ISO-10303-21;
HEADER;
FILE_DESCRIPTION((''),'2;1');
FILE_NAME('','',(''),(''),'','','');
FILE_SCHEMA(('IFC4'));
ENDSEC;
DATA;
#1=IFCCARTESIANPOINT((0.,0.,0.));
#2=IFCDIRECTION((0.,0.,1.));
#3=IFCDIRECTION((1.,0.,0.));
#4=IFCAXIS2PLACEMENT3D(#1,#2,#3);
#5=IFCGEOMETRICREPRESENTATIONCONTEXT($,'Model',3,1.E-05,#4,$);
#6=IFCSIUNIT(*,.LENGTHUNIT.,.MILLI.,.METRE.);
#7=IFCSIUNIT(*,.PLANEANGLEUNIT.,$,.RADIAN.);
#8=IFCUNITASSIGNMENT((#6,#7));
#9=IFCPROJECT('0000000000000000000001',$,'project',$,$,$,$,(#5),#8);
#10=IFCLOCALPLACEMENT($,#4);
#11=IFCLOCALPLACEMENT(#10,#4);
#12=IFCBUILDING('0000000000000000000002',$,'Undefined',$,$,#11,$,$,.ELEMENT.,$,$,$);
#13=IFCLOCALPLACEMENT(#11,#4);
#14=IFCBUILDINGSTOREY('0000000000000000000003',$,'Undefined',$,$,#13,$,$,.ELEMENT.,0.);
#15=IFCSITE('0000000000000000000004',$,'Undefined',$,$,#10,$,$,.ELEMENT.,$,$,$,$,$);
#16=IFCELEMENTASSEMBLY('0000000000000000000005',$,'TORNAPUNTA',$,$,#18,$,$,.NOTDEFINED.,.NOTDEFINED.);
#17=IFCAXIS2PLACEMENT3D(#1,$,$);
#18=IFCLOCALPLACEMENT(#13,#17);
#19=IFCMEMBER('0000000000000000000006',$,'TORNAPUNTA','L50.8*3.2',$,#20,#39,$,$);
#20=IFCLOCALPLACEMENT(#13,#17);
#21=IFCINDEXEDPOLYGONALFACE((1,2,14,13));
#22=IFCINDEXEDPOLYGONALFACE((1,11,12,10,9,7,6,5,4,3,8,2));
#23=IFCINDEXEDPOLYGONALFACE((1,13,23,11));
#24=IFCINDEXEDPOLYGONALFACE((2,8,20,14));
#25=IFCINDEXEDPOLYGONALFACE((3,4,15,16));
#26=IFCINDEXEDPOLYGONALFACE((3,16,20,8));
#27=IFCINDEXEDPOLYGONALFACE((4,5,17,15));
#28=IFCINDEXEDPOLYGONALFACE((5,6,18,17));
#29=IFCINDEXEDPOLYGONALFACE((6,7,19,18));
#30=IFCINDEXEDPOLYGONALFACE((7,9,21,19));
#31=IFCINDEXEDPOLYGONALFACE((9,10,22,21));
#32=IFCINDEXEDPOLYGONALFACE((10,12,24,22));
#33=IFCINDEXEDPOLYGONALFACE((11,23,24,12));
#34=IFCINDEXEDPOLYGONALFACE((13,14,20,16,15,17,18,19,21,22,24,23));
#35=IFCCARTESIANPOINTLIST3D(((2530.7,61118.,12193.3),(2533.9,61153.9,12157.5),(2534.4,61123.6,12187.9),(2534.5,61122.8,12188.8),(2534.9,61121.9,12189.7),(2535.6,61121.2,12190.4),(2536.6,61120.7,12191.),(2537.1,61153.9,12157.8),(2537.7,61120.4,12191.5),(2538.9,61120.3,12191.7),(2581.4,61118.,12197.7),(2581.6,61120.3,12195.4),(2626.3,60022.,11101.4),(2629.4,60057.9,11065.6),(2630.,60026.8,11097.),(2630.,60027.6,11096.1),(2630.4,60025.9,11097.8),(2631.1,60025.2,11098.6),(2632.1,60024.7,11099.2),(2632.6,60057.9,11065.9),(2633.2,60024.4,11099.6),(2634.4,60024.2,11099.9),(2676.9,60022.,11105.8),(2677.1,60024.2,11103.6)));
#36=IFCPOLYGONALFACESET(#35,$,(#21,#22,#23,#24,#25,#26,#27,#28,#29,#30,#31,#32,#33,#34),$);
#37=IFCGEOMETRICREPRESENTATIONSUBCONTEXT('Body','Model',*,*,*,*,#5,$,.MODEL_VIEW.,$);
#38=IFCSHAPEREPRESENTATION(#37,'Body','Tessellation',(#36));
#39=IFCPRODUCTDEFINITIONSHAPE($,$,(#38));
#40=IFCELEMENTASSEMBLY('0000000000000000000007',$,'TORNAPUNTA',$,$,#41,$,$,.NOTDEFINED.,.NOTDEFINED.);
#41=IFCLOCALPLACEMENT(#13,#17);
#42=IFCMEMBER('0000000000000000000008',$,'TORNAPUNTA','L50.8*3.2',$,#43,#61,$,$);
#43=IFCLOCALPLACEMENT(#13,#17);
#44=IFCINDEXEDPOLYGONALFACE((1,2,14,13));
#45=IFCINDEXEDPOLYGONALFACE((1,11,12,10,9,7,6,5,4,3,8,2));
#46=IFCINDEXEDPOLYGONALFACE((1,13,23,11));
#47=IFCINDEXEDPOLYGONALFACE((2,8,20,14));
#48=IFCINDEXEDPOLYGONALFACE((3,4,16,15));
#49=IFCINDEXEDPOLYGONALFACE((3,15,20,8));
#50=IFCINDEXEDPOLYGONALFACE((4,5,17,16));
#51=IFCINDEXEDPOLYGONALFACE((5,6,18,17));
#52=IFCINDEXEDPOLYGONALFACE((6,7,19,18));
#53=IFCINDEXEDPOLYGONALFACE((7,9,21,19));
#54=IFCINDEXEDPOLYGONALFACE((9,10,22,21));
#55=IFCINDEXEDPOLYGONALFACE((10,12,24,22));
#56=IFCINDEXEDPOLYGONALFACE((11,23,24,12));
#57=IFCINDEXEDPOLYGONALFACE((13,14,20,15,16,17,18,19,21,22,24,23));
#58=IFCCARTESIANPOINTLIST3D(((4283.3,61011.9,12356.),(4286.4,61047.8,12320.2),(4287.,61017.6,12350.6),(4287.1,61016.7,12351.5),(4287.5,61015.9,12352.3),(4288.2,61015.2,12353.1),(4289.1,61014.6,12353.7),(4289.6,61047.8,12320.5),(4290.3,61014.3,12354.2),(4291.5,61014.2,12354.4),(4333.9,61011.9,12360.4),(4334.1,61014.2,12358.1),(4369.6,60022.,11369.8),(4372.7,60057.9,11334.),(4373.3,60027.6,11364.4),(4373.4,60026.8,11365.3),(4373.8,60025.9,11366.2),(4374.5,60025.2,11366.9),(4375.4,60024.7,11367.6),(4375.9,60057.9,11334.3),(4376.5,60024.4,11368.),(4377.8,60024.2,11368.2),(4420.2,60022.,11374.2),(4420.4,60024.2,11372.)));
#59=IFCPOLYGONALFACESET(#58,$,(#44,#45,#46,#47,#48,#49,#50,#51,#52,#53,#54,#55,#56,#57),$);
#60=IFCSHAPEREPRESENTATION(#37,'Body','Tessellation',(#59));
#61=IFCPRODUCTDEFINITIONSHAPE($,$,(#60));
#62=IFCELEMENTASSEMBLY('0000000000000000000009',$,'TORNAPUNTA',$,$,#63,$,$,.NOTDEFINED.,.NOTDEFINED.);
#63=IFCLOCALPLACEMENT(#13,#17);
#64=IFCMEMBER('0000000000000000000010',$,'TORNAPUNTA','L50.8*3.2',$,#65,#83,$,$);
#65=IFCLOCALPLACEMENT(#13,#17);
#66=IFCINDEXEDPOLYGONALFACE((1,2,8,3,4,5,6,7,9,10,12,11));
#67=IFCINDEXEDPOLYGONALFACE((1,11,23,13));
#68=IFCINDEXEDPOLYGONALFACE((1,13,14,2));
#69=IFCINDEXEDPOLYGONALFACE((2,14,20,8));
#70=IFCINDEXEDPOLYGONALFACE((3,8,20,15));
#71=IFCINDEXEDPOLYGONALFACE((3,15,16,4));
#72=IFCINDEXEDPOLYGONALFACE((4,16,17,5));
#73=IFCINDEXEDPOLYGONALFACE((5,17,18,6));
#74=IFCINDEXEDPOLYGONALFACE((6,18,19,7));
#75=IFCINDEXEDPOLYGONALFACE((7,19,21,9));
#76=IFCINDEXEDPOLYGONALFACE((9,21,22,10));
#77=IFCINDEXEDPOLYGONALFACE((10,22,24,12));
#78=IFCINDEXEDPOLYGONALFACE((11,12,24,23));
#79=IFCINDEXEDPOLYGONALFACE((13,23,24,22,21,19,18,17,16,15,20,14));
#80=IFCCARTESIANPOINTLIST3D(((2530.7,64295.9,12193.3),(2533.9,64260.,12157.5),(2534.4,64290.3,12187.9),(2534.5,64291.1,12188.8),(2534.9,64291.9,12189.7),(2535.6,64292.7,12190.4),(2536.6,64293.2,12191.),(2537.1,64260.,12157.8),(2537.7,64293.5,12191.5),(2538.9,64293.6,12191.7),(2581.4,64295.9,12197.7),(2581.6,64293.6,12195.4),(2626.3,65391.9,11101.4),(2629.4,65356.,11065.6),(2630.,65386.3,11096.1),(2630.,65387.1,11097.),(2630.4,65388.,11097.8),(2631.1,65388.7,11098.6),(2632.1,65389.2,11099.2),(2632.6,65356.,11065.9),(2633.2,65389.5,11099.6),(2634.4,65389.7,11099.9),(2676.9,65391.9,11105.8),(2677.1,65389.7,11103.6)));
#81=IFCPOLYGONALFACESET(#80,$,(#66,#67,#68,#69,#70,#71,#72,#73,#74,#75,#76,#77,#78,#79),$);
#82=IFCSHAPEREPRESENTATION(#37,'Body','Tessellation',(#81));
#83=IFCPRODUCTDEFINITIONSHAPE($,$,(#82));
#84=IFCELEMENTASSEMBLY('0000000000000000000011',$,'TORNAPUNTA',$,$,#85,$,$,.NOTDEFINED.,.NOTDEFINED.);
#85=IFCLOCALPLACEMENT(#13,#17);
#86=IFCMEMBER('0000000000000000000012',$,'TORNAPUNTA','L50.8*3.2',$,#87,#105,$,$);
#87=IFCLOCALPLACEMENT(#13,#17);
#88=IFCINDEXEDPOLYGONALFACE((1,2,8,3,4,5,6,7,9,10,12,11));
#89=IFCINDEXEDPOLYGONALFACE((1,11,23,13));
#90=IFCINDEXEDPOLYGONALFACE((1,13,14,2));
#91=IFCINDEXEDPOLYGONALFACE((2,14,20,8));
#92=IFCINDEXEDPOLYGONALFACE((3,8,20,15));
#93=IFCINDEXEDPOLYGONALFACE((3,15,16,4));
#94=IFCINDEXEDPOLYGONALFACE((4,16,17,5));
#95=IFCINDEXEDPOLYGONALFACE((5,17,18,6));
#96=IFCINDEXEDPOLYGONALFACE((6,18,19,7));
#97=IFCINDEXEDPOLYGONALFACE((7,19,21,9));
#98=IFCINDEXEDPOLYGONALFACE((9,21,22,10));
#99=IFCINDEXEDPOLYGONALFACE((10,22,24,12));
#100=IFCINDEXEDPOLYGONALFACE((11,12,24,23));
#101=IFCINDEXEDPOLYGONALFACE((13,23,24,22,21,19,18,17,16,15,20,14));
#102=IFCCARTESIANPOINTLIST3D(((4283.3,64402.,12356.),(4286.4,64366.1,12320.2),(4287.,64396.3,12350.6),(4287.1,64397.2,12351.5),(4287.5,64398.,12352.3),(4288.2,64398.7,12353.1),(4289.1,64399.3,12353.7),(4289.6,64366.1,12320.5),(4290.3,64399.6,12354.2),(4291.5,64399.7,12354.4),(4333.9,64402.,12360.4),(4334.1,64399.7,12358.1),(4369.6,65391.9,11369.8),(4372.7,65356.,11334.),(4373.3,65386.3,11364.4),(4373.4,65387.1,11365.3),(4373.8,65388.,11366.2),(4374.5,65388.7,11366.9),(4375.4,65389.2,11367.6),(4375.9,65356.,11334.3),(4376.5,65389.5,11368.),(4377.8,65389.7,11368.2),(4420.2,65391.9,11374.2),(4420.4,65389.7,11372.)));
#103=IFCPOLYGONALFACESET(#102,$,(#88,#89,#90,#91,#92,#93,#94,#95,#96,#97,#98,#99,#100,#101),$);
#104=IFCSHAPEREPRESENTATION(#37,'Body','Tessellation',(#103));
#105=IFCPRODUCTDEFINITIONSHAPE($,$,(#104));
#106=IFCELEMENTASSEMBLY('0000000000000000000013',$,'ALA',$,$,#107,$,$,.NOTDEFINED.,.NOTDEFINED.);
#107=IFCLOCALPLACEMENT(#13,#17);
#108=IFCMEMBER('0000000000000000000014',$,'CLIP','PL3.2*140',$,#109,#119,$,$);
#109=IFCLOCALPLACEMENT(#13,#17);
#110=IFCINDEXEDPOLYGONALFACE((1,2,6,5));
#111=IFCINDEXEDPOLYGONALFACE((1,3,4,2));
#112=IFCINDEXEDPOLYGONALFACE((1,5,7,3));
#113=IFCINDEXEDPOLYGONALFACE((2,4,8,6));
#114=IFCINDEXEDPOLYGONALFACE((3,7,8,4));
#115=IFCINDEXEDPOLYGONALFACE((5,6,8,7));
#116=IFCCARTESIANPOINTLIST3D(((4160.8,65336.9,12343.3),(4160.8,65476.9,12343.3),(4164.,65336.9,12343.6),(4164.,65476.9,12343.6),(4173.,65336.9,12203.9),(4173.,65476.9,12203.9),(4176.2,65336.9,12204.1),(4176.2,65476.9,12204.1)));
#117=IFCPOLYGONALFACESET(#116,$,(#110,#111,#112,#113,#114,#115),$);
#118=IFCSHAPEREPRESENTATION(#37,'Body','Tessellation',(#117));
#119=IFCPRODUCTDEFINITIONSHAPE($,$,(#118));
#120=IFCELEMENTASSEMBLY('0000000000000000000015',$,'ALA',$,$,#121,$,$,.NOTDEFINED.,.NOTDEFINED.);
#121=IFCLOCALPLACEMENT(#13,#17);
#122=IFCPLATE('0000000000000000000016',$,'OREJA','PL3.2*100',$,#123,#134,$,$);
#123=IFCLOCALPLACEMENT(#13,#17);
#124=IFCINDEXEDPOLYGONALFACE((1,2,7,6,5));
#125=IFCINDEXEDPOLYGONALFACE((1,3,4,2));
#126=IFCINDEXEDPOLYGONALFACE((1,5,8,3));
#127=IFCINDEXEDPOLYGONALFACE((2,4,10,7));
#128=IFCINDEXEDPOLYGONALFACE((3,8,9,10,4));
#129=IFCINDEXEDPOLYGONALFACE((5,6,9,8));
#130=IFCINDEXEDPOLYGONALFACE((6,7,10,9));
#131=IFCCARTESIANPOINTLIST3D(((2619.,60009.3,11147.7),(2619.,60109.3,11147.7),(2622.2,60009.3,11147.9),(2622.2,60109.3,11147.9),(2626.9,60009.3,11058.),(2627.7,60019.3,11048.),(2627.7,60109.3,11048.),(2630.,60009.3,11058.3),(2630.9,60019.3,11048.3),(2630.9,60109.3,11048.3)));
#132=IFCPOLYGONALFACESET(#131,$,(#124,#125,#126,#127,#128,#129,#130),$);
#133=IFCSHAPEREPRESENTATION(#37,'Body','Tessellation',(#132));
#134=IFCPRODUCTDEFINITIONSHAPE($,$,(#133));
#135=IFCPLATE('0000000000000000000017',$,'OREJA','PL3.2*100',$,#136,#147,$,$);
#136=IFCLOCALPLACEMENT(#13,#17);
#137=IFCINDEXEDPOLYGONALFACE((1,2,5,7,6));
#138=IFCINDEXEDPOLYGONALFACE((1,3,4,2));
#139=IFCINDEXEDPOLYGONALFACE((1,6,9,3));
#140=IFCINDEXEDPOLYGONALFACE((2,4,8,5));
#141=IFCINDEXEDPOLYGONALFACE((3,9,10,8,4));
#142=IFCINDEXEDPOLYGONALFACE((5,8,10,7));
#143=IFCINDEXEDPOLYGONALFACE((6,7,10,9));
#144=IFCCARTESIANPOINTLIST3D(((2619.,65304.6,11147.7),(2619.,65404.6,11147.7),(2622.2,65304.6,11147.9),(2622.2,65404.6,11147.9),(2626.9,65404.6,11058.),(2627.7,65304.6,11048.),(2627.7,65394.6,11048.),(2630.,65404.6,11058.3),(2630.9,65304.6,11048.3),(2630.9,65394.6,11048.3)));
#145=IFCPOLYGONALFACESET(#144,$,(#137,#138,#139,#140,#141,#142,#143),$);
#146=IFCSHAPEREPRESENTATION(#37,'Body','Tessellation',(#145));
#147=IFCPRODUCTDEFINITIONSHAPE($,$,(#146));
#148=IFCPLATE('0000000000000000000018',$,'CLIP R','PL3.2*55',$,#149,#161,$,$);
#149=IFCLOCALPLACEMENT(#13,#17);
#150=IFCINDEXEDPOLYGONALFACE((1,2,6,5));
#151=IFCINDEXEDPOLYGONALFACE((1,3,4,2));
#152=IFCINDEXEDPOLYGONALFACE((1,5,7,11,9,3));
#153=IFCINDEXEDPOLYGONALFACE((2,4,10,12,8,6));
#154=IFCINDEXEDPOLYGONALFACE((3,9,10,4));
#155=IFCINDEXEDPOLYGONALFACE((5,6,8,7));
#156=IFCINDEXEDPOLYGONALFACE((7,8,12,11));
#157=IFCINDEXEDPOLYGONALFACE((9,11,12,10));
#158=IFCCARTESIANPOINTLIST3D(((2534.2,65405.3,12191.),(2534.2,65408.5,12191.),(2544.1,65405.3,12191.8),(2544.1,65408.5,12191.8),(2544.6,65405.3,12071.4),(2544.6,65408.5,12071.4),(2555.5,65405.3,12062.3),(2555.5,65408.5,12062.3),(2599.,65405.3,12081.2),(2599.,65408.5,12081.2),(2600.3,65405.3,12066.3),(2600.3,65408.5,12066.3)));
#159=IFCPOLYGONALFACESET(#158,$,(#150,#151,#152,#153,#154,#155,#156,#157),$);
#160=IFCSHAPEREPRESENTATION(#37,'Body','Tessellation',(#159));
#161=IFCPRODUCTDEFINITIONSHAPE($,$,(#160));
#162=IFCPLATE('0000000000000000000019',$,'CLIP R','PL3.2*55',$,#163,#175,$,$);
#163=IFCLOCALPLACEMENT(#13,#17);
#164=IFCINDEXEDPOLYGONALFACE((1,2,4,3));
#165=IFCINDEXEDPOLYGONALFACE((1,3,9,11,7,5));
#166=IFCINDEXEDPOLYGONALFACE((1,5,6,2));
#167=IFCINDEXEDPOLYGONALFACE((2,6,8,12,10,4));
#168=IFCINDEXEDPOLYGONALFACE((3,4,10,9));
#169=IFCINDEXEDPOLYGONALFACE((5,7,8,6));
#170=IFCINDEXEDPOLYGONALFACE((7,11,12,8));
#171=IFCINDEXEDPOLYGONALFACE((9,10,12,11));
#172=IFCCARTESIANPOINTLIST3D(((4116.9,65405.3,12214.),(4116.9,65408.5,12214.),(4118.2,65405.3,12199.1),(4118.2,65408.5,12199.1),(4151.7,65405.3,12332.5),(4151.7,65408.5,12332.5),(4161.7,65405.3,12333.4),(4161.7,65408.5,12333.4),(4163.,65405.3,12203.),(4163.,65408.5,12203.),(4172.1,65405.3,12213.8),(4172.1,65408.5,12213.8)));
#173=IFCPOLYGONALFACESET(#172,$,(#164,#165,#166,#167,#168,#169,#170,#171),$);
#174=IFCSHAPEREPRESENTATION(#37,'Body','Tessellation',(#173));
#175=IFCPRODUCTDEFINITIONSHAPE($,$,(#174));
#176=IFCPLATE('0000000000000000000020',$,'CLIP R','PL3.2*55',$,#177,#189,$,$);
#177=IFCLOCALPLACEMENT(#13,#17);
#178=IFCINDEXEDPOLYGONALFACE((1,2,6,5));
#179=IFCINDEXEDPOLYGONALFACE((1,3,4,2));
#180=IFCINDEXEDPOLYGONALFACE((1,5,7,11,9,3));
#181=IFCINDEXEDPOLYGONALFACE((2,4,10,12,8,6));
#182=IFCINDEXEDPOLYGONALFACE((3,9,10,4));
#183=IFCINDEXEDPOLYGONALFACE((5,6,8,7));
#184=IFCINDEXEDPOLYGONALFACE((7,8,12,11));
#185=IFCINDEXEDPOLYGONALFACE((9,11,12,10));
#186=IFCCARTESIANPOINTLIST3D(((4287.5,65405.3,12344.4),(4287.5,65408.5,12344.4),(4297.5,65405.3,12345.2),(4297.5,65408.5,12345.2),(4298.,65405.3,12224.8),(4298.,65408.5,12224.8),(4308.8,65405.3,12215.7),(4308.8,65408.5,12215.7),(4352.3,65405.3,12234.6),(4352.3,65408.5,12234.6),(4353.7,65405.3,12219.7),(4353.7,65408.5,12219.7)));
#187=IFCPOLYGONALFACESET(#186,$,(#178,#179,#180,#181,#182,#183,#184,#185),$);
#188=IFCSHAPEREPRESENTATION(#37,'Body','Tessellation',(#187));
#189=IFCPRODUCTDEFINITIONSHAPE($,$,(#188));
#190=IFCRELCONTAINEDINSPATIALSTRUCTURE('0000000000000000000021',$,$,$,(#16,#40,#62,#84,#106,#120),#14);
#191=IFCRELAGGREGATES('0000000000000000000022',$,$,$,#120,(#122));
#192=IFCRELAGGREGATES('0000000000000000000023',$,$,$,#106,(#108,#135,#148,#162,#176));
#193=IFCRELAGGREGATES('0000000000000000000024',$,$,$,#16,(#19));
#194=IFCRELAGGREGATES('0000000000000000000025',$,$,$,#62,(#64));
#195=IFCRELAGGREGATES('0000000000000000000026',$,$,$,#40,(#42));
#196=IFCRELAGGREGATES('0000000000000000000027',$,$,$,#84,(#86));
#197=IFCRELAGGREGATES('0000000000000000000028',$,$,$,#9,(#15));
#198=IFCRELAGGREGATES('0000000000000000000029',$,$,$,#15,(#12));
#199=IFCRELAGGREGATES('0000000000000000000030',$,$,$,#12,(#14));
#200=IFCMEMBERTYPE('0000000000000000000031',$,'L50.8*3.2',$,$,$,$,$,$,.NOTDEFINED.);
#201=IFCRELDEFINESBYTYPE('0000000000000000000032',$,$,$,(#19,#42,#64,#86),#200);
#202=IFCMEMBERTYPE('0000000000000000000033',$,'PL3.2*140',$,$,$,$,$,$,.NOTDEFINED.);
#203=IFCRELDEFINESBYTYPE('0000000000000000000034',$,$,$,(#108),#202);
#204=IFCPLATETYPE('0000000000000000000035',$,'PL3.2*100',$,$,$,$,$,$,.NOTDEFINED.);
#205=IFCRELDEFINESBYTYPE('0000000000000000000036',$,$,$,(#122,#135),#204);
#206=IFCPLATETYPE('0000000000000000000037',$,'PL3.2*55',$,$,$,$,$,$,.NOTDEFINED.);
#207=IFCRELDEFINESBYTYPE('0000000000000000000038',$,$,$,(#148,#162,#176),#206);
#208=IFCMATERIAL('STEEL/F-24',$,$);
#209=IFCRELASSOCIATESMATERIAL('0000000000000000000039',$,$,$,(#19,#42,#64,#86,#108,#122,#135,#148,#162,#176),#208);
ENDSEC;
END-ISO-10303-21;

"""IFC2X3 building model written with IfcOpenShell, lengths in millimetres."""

from ifc_helpers import new_model, si_unit, frame, origin_with_axes, origin_2d_with_axis, place, context, subcontext, project, spatial, polyline, rectangle, l_section, outline, extrude, material, type_object, element, aggregate, save


model = new_model("IFC2X3")

# Units and contexts
model_context = context("Model", 3, precision=1e-05, world=origin_with_axes())
body_context = subcontext(model_context, "Body", "Model", "MODEL_VIEW")
ifc_project = project(units=[si_unit("LENGTHUNIT", "METRE", prefix="MILLI"), si_unit("PLANEANGLEUNIT", "RADIAN")], contexts=[model_context])

# Site, building, storey
site_placement = place(None, origin_with_axes())
site = spatial("IfcSite", under=ifc_project, at=site_placement, Name="Undefined", CompositionType="ELEMENT")
building_placement = place(site_placement, origin_with_axes())
building = spatial("IfcBuilding", under=site, at=building_placement, Name="Undefined", CompositionType="ELEMENT")
storey_placement = place(building_placement, origin_with_axes())
storey = spatial("IfcBuildingStorey", under=building, at=storey_placement, Name="Undefined", CompositionType="ELEMENT", Elevation=0.0)

# Element assemblies, members
assembly_1_placement = place(storey_placement, origin_with_axes())
assembly_1 = element("IfcElementAssembly", 1, at=assembly_1_placement, inside=storey, Name="TORNAPUNTA", AssemblyPlace="NOTDEFINED", PredefinedType="NOTDEFINED")
ifc_material_1 = material(Name="STEEL/F-24")
member_type_1 = type_object("IfcMemberType", Name="L50.8*3.2", PredefinedType="NOTDEFINED")
member_1_placement = place(assembly_1_placement, frame((2557.6, 61135.9, 12177.6), z_axis=(0.061628, 0.707107, -0.704416), x_axis=(0.061628, -0.707107, -0.704416)))
member_1 = element("IfcMember", 2, at=member_1_placement, type_object=member_type_1, material=ifc_material_1, Name="TORNAPUNTA", Description="L50.8*3.2", context=body_context, shape_type="SweptSolid", body=[
    extrude(l_section(Depth=50.8, Width=50.8, Thickness=3.2, FilletRadius=4.8, at=origin_2d_with_axis()), frame((1550.0, 0.0, 0.0), z_axis=(-1.0, 0.0, 0.0), x_axis=(0.0, -1.0, 0.0)), (0.0, 0.0, 1.0), 1550.0),
])
assembly_2_placement = place(storey_placement, origin_with_axes())
assembly_2 = element("IfcElementAssembly", 3, at=assembly_2_placement, inside=storey, Name="TORNAPUNTA", AssemblyPlace="NOTDEFINED", PredefinedType="NOTDEFINED")
member_2_placement = place(assembly_2_placement, frame((4310.2, 61029.9, 12340.3), z_axis=(0.061628, 0.707107, -0.704416), x_axis=(0.061628, -0.707107, -0.704416)))
member_2 = element("IfcMember", 4, at=member_2_placement, type_object=member_type_1, material=ifc_material_1, Name="TORNAPUNTA", Description="L50.8*3.2", context=body_context, shape_type="SweptSolid", body=[
    extrude(l_section(Depth=50.8, Width=50.8, Thickness=3.2, FilletRadius=4.8, at=origin_2d_with_axis()), frame((1400.0, 0.0, 0.0), z_axis=(-1.0, 0.0, 0.0), x_axis=(0.0, -1.0, 0.0)), (0.0, 0.0, 1.0), 1400.0),
])
assembly_3_placement = place(storey_placement, origin_with_axes())
assembly_3 = element("IfcElementAssembly", 5, at=assembly_3_placement, inside=storey, Name="TORNAPUNTA", AssemblyPlace="NOTDEFINED", PredefinedType="NOTDEFINED")
member_3_placement = place(assembly_3_placement, frame((2653.1, 65374.0, 11085.7), z_axis=(0.061628, -0.707107, -0.704416), x_axis=(-0.061628, -0.707107, 0.704416)))
member_3 = element("IfcMember", 6, at=member_3_placement, type_object=member_type_1, material=ifc_material_1, Name="TORNAPUNTA", Description="L50.8*3.2", context=body_context, shape_type="SweptSolid", body=[
    extrude(l_section(Depth=50.8, Width=50.8, Thickness=3.2, FilletRadius=4.8, at=origin_2d_with_axis()), frame((1550.0, 0.0, 0.0), z_axis=(-1.0, 0.0, 0.0), x_axis=(0.0, -1.0, 0.0)), (0.0, 0.0, 1.0), 1550.0),
])
assembly_4_placement = place(storey_placement, origin_with_axes())
assembly_4 = element("IfcElementAssembly", 7, at=assembly_4_placement, inside=storey, Name="TORNAPUNTA", AssemblyPlace="NOTDEFINED", PredefinedType="NOTDEFINED")
member_4_placement = place(assembly_4_placement, frame((4396.5, 65374.0, 11354.1), z_axis=(0.061628, -0.707107, -0.704416), x_axis=(-0.061628, -0.707107, 0.704416)))
member_4 = element("IfcMember", 8, at=member_4_placement, type_object=member_type_1, material=ifc_material_1, Name="TORNAPUNTA", Description="L50.8*3.2", context=body_context, shape_type="SweptSolid", body=[
    extrude(l_section(Depth=50.8, Width=50.8, Thickness=3.2, FilletRadius=4.8, at=origin_2d_with_axis()), frame((1400.0, 0.0, 0.0), z_axis=(-1.0, 0.0, 0.0), x_axis=(0.0, -1.0, 0.0)), (0.0, 0.0, 1.0), 1400.0),
])
assembly_5_placement = place(storey_placement, origin_with_axes())
assembly_5 = element("IfcElementAssembly", 9, at=assembly_5_placement, inside=storey, Name="ALA", AssemblyPlace="NOTDEFINED", PredefinedType="NOTDEFINED")
member_type_2 = type_object("IfcMemberType", Name="PL3.2*140", PredefinedType="NOTDEFINED")
member_5_placement = place(assembly_5_placement, frame((4162.4, 65406.9, 12343.5), z_axis=(0.0, -1.0, 0.0), x_axis=(0.087155, 0.0, -0.996195)))
member_5 = element("IfcMember", 10, at=member_5_placement, type_object=member_type_2, material=ifc_material_1, Name="CLIP", Description="PL3.2*140", context=body_context, shape_type="SweptSolid", body=[
    extrude(rectangle(XDim=3.2, YDim=140.0, at=origin_2d_with_axis()), frame((140.0, 0.0, 0.0), z_axis=(-1.0, 0.0, 0.0), x_axis=(0.0, -1.0, 0.0)), (0.0, 0.0, 1.0), 140.0),
])

# Element assembly, plate
assembly_6_placement = place(storey_placement, origin_with_axes())
assembly_6 = element("IfcElementAssembly", 11, at=assembly_6_placement, inside=storey, Name="ALA", AssemblyPlace="NOTDEFINED", PredefinedType="NOTDEFINED")
plate_type_1 = type_object("IfcPlateType", Name="PL3.2*100", PredefinedType="NOTDEFINED")
plate_1_placement = place(assembly_6_placement, frame((2629.3, 60109.3, 11048.2), z_axis=(-0.996195, 0.0, -0.087155), x_axis=(0.0, -1.0, 0.0)))
plate_1 = element("IfcPlate", 12, at=plate_1_placement, type_object=plate_type_1, material=ifc_material_1, Name="OREJA", Description="PL3.2*100", context=body_context, shape_type="SweptSolid", body=[
    extrude(outline(polyline([(0.0, 0.0), (90.0, 0.0), (100.0, 10.0), (100.0, 100.0), (0.0, 100.0), (0.0, 0.0)])), frame((0.0, 0.0, -1.6), z_axis=(0.0, 0.0, 1.0), x_axis=(1.0, 0.0, 0.0)), (0.0, 0.0, 1.0), 3.2),
])
aggregate(assembly_6, [plate_1])

# Plates
plate_2_placement = place(assembly_5_placement, frame((2629.3, 65304.6, 11048.2), z_axis=(0.996195, 0.0, 0.087155), x_axis=(0.0, 1.0, 0.0)))
plate_2 = element("IfcPlate", 13, at=plate_2_placement, type_object=plate_type_1, material=ifc_material_1, Name="OREJA", Description="PL3.2*100", context=body_context, shape_type="SweptSolid", body=[
    extrude(outline(polyline([(0.0, 0.0), (90.0, 0.0), (100.0, 10.0), (100.0, 100.0), (0.0, 100.0), (0.0, 0.0)])), frame((0.0, 0.0, -1.6), z_axis=(0.0, 0.0, 1.0), x_axis=(1.0, 0.0, 0.0)), (0.0, 0.0, 1.0), 3.2),
])
plate_type_2 = type_object("IfcPlateType", Name="PL3.2*55", PredefinedType="NOTDEFINED")
plate_3_placement = place(assembly_5_placement, frame((2534.2, 65406.9, 12191.0), z_axis=(0.0, 1.0, 0.0), x_axis=(0.996195, 0.0, 0.087155)))
plate_3 = element("IfcPlate", 14, at=plate_3_placement, type_object=plate_type_2, material=ifc_material_1, Name="CLIP R", Description="PL3.2*55", context=body_context, shape_type="SweptSolid", body=[
    extrude(outline(polyline([(0.0, 0.0), (10.0, 0.0), (55.0, 115.0), (55.0, 130.0), (10.0, 130.0), (0.0, 120.0), (0.0, 0.0)])), frame((0.0, 0.0, -1.6), z_axis=(0.0, 0.0, 1.0), x_axis=(1.0, 0.0, 0.0)), (0.0, 0.0, 1.0), 3.2),
])
plate_4_placement = place(assembly_5_placement, frame((4161.7, 65406.9, 12333.4), z_axis=(0.0, -1.0, 0.0), x_axis=(-0.996195, 0.0, -0.087155)))
plate_4 = element("IfcPlate", 15, at=plate_4_placement, type_object=plate_type_2, material=ifc_material_1, Name="CLIP R", Description="PL3.2*55", context=body_context, shape_type="SweptSolid", body=[
    extrude(outline(polyline([(0.0, 0.0), (10.0, 0.0), (55.0, 115.0), (55.0, 130.0), (10.0, 130.0), (0.0, 120.0), (0.0, 0.0)])), frame((0.0, 0.0, -1.6), z_axis=(0.0, 0.0, 1.0), x_axis=(1.0, 0.0, 0.0)), (0.0, 0.0, 1.0), 3.2),
])
plate_5_placement = place(assembly_5_placement, frame((4287.5, 65406.9, 12344.4), z_axis=(0.0, 1.0, 0.0), x_axis=(0.996195, 0.0, 0.087155)))
plate_5 = element("IfcPlate", 16, at=plate_5_placement, type_object=plate_type_2, material=ifc_material_1, Name="CLIP R", Description="PL3.2*55", context=body_context, shape_type="SweptSolid", body=[
    extrude(outline(polyline([(0.0, 0.0), (10.0, 0.0), (55.0, 115.0), (55.0, 130.0), (10.0, 130.0), (0.0, 120.0), (0.0, 0.0)])), frame((0.0, 0.0, -1.6), z_axis=(0.0, 0.0, 1.0), x_axis=(1.0, 0.0, 0.0)), (0.0, 0.0, 1.0), 3.2),
])
aggregate(assembly_5, [member_5, plate_2, plate_3, plate_4, plate_5])

aggregate(assembly_1, [member_1])
aggregate(assembly_3, [member_3])
aggregate(assembly_2, [member_2])
aggregate(assembly_4, [member_4])

save(model, "model.ifc")
